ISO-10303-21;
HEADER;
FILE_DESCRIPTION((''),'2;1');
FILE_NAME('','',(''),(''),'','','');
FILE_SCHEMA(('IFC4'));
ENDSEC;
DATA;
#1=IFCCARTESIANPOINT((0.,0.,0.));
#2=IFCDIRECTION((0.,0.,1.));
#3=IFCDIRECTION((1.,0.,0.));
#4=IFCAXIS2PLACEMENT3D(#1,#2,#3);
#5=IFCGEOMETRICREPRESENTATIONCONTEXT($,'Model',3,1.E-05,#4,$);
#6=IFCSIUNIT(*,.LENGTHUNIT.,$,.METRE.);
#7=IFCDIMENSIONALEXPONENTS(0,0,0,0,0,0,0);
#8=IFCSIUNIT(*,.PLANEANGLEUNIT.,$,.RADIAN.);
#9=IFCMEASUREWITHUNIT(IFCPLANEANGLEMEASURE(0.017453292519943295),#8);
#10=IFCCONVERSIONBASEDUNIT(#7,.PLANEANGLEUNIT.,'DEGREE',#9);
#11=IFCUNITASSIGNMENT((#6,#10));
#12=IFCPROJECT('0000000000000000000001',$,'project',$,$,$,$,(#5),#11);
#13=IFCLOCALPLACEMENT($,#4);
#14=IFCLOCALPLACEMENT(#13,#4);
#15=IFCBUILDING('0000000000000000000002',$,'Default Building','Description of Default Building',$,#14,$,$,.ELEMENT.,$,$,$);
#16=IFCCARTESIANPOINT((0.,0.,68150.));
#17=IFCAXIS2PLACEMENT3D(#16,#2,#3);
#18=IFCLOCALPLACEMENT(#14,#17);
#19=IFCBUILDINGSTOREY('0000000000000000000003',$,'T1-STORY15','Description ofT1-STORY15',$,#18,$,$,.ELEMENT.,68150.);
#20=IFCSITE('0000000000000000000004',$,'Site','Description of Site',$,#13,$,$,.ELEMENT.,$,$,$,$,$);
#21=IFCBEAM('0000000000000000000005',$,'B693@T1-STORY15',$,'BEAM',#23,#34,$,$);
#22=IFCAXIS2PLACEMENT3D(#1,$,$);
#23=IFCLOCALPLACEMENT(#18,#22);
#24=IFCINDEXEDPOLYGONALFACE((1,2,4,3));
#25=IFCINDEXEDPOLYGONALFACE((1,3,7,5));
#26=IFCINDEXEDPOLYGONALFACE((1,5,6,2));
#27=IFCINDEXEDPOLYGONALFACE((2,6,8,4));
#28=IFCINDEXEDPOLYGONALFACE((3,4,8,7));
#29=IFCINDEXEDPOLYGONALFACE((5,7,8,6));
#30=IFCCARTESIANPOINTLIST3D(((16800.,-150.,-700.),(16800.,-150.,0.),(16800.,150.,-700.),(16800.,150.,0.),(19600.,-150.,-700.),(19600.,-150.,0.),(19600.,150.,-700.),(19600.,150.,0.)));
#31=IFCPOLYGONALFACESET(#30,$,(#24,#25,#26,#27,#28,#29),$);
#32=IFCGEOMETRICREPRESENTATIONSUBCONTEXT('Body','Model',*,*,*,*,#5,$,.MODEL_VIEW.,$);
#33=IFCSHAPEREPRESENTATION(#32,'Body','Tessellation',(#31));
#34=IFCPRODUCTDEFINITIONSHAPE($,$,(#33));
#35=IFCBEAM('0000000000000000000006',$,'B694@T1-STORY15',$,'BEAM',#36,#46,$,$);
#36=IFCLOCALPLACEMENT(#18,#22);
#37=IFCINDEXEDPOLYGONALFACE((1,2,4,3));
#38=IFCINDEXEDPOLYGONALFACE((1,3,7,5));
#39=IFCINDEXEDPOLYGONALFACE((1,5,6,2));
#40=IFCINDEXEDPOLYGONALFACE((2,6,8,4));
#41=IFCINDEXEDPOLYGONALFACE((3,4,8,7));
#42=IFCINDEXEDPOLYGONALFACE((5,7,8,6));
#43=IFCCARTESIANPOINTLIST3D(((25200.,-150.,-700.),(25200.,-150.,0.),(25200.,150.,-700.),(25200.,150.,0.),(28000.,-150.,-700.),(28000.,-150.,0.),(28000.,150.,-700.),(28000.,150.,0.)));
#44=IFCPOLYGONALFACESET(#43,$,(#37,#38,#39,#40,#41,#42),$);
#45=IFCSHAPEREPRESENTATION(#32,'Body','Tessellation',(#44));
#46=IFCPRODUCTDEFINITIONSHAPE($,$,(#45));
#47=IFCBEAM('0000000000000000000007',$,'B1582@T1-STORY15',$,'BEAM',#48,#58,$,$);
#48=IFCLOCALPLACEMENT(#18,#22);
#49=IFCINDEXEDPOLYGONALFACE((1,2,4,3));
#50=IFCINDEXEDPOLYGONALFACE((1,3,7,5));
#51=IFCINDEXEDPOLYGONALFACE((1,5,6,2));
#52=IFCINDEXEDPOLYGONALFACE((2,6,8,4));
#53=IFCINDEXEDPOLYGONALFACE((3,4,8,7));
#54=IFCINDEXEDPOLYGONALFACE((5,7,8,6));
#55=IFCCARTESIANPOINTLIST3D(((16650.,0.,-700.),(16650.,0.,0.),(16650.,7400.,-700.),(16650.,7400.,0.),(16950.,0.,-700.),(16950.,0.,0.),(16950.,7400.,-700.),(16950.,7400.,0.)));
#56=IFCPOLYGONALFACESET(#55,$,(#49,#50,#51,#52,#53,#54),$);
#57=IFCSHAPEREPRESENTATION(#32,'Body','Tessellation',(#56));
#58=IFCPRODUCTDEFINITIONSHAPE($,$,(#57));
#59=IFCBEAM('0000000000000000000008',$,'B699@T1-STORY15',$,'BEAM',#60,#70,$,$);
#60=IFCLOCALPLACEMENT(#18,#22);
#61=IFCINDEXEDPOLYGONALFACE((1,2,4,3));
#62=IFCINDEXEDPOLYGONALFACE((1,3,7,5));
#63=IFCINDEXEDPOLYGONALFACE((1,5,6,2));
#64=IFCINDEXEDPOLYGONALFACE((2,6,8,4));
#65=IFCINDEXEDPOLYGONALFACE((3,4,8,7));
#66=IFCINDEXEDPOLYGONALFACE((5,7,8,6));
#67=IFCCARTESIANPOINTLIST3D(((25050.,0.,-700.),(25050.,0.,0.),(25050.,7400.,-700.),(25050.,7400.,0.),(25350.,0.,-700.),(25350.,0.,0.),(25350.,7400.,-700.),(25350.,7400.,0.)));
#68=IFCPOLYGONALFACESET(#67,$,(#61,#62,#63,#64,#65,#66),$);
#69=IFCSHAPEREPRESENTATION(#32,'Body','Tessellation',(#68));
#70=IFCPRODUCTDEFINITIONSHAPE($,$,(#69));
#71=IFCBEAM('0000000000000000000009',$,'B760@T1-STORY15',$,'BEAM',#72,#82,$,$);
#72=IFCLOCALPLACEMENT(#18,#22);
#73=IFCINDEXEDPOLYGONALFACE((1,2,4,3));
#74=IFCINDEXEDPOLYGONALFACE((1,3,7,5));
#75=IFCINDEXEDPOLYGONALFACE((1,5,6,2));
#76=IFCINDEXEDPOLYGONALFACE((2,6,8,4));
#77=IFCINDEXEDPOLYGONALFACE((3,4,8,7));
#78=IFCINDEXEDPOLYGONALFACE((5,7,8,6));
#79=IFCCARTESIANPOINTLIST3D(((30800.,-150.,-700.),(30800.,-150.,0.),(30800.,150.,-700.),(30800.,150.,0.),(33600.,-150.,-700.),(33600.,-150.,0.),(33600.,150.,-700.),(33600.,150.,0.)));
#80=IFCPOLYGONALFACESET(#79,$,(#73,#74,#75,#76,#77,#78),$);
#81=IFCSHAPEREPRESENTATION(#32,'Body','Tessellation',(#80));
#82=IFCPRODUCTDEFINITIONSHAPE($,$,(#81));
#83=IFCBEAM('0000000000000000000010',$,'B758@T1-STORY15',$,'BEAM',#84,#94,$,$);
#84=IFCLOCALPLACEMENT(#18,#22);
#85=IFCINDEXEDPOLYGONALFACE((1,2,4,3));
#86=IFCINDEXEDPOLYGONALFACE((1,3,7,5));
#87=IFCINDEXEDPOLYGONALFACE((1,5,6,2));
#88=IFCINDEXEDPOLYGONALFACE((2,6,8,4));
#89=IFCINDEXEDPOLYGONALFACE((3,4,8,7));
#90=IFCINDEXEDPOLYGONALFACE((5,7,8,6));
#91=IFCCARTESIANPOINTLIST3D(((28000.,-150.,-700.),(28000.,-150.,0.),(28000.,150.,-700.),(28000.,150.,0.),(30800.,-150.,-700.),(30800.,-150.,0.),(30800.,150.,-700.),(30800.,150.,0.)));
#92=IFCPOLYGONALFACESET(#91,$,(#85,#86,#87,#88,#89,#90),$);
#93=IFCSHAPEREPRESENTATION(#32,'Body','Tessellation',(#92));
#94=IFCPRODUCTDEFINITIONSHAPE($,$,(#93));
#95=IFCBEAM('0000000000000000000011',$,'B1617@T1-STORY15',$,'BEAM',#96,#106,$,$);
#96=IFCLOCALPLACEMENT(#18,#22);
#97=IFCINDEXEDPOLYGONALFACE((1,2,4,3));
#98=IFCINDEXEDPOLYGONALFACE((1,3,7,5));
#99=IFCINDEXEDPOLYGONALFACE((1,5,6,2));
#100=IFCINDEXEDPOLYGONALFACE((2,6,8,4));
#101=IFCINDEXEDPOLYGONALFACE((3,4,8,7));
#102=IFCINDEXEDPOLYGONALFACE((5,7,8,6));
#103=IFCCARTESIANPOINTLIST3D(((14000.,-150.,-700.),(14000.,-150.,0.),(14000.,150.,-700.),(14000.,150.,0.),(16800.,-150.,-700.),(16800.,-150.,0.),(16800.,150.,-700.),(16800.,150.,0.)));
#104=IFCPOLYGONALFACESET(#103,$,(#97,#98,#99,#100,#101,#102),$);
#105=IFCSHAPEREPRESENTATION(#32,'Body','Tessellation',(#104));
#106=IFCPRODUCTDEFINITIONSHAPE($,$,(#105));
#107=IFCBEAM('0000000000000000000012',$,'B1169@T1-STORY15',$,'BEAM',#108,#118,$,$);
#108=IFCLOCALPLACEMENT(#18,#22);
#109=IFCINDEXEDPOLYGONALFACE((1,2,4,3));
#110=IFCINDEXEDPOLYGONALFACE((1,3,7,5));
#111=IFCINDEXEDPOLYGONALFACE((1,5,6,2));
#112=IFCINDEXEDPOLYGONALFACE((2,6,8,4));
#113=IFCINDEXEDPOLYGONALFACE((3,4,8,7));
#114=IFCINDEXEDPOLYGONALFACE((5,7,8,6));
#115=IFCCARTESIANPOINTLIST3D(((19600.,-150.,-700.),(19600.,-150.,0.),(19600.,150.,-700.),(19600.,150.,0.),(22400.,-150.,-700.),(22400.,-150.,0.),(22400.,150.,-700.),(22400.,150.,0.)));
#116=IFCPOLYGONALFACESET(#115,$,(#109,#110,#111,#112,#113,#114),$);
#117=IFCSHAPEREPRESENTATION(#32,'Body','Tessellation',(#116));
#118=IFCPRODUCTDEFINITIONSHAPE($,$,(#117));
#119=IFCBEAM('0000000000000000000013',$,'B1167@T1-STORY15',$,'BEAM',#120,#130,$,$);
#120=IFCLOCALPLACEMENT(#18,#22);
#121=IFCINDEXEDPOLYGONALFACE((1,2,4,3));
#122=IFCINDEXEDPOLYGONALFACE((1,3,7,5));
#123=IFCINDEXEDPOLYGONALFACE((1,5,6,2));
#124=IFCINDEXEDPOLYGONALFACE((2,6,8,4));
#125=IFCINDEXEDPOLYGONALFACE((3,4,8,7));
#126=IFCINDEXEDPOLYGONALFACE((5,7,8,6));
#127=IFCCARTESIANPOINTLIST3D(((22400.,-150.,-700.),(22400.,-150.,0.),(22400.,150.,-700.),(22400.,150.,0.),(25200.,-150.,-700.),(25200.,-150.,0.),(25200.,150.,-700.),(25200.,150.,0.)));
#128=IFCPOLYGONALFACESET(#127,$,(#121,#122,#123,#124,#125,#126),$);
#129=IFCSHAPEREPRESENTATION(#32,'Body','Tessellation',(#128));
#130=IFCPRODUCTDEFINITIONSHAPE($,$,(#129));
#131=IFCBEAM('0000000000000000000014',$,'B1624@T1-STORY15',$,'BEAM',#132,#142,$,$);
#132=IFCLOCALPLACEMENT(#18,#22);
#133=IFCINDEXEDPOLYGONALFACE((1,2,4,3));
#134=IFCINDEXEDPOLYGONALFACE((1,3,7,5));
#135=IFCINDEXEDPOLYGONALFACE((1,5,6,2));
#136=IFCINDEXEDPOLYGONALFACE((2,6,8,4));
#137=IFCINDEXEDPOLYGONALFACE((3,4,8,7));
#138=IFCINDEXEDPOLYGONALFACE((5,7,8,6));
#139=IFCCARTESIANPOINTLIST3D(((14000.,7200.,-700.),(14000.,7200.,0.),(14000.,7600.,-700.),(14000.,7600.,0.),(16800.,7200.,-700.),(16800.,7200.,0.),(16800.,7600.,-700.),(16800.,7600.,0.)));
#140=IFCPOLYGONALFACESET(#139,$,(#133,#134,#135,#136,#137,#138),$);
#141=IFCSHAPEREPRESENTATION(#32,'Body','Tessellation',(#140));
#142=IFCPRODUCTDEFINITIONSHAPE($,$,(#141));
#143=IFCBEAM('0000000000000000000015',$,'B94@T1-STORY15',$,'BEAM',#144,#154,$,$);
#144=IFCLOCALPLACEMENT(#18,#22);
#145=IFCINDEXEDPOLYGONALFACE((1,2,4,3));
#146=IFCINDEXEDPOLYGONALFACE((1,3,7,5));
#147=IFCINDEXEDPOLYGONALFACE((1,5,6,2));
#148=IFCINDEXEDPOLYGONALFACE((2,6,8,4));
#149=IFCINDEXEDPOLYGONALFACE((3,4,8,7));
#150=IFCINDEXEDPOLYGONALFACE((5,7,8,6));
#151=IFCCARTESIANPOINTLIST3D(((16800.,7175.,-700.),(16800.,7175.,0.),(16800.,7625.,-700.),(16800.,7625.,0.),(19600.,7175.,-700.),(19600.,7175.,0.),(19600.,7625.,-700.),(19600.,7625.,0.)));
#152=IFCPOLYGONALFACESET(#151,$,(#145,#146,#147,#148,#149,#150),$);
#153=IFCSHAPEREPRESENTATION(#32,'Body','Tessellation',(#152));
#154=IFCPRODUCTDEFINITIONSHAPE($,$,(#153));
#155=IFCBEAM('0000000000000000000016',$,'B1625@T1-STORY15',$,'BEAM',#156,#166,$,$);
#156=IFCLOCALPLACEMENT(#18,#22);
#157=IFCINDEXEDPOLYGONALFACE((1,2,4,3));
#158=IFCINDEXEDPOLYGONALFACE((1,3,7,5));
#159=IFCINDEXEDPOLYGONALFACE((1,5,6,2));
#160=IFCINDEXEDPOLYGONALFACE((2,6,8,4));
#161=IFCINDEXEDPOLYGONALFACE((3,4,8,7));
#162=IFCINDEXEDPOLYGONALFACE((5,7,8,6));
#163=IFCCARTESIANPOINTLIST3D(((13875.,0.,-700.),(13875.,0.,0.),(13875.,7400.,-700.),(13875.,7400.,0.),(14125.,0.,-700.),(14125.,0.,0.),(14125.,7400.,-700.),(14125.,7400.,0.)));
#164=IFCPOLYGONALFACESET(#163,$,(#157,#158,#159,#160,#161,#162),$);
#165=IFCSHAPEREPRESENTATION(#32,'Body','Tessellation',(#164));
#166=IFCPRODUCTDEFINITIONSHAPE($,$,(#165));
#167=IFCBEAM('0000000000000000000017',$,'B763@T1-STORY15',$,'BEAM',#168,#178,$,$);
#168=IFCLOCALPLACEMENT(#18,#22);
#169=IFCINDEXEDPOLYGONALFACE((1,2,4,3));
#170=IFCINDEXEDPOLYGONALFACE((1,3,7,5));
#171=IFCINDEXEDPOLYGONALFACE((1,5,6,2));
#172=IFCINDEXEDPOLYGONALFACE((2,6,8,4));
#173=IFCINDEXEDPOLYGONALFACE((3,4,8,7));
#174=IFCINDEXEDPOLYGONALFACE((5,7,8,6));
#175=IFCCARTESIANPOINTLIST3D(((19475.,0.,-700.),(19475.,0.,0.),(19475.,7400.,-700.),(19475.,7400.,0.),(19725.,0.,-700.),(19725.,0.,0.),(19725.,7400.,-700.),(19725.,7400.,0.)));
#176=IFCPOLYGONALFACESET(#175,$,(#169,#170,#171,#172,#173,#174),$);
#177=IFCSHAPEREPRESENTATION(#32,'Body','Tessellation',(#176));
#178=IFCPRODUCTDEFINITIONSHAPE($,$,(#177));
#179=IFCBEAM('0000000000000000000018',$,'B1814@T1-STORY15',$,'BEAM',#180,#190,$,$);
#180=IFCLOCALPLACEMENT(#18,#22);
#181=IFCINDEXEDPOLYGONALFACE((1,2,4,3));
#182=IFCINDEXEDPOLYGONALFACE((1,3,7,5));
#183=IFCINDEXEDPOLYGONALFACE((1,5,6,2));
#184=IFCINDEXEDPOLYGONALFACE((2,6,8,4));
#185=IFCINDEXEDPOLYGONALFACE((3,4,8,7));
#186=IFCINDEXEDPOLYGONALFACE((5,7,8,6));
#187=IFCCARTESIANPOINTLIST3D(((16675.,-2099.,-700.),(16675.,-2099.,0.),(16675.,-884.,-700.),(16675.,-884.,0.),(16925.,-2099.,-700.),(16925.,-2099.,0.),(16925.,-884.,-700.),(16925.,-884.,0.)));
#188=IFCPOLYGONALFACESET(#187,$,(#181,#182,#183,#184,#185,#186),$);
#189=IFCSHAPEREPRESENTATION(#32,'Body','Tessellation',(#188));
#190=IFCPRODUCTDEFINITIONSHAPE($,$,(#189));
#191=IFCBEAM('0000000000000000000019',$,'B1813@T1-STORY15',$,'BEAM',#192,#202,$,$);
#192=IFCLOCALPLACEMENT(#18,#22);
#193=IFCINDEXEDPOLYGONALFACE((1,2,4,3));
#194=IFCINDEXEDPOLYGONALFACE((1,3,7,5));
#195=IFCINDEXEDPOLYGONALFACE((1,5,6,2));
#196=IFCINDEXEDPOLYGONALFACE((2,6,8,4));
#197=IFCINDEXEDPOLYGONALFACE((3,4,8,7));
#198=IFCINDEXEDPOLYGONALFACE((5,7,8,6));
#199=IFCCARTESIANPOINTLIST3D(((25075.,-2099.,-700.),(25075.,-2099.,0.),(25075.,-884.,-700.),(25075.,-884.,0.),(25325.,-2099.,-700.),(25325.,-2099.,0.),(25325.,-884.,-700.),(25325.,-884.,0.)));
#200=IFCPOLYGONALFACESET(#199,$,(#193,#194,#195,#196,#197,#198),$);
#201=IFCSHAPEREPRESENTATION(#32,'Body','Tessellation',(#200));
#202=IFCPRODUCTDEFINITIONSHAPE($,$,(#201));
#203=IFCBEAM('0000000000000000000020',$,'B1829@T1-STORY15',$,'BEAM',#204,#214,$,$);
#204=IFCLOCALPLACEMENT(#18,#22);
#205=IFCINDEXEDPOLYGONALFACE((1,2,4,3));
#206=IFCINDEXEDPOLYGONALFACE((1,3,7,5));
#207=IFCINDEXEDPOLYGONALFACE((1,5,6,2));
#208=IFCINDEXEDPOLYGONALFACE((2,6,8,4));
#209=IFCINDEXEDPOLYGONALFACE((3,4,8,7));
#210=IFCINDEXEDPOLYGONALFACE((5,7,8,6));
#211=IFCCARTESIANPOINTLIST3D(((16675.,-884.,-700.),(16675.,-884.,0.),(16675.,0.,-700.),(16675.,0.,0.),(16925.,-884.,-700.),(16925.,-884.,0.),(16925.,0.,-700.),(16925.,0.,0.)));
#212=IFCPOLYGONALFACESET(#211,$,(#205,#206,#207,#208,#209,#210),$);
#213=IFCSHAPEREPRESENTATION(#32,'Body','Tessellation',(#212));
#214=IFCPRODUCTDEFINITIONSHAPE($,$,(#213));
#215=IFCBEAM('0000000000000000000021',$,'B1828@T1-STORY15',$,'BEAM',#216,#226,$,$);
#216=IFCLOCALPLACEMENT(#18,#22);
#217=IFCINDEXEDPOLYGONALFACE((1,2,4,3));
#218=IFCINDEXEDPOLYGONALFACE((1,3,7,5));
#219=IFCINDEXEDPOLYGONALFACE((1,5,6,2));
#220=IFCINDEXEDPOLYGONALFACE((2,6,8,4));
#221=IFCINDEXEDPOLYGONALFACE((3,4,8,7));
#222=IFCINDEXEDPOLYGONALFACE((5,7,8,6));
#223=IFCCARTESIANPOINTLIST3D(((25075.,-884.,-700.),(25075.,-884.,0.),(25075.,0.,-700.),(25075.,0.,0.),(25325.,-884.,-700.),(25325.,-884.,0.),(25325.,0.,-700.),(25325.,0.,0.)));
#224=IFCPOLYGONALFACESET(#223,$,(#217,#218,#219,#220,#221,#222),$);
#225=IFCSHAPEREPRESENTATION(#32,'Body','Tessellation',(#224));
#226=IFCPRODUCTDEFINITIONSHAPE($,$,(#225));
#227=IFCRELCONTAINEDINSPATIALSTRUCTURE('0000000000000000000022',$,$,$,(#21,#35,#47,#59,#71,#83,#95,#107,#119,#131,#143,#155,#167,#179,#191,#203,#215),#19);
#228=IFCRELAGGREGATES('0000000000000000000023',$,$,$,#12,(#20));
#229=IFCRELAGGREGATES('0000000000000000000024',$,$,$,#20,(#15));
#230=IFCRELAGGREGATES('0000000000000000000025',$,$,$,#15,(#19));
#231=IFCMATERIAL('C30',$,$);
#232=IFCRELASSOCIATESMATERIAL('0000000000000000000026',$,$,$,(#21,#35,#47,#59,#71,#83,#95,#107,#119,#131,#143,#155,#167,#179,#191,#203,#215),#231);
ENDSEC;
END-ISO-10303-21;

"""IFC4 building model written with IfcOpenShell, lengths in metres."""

from ifc_helpers import new_model, entity, si_unit, converted_unit, frame, origin_with_axes, place, context, subcontext, project, spatial, rectangle, extrude, material, element, save


model = new_model("IFC4")

# Units and contexts
model_context = context("Model", 3, precision=1e-05, world=origin_with_axes())
body_context = subcontext(model_context, "Body", "Model", "MODEL_VIEW")
ifc_project = project(units=[si_unit("LENGTHUNIT", "METRE"), converted_unit("PLANEANGLEUNIT", "DEGREE", entity("IfcPlaneAngleMeasure", 0.017453292519943295), si_unit("PLANEANGLEUNIT", "RADIAN"), dimensions=[0, 0, 0, 0, 0, 0, 0])], contexts=[model_context])

# Site, building, storey
site_placement = place(None, origin_with_axes())
site = spatial("IfcSite", under=ifc_project, at=site_placement, Name="Site", Description="Description of Site", CompositionType="ELEMENT")
building_placement = place(site_placement, origin_with_axes())
building = spatial("IfcBuilding", under=site, at=building_placement, Name="Default Building", Description="Description of Default Building", CompositionType="ELEMENT")
storey_placement = place(building_placement, frame((0.0, 0.0, 68150.0), z_axis=(0.0, 0.0, 1.0), x_axis=(1.0, 0.0, 0.0)))
storey = spatial("IfcBuildingStorey", under=building, at=storey_placement, Name="T1-STORY15", Description="Description ofT1-STORY15", CompositionType="ELEMENT", Elevation=68150.0)

# Beams
ifc_material_1 = material(Name="C30")
for number, where, z_axis, x_axis, name in (
    (1, (16800.0, 0.0, -350.0), (1.0, 0.0, 0.0), (0.0, 1.0, 0.0), "B693@T1-STORY15"),
    (2, (25200.0, 0.0, -350.0), (1.0, 0.0, 0.0), (0.0, 1.0, 0.0), "B694@T1-STORY15"),
):
    element("IfcBeam", number, at=place(storey_placement, frame(where, z_axis=z_axis, x_axis=x_axis)), inside=storey, material=ifc_material_1, Name=name, ObjectType="BEAM", context=body_context, shape_type="SweptSolid", body=[
        extrude(rectangle(XDim=300.0, YDim=700.0), origin_with_axes(), (0.0, 0.0, 1.0), 2800.0),
    ])
for number, where, z_axis, x_axis, name in (
    (3, (16800.0, 0.0, -350.0), (0.0, 1.0, 0.0), (-1.0, 0.0, 0.0), "B1582@T1-STORY15"),
    (4, (25200.0, 0.0, -350.0), (0.0, 1.0, 0.0), (-1.0, 0.0, 0.0), "B699@T1-STORY15"),
):
    element("IfcBeam", number, at=place(storey_placement, frame(where, z_axis=z_axis, x_axis=x_axis)), inside=storey, material=ifc_material_1, Name=name, ObjectType="BEAM", context=body_context, shape_type="SweptSolid", body=[
        extrude(rectangle(XDim=300.0, YDim=700.0), origin_with_axes(), (0.0, 0.0, 1.0), 7400.0),
    ])
for number, where, z_axis, x_axis, name in (
    (5, (30800.0, 0.0, -350.0), (1.0, 0.0, 0.0), (0.0, 1.0, 0.0), "B760@T1-STORY15"),
    (6, (28000.0, 0.0, -350.0), (1.0, 0.0, 0.0), (0.0, 1.0, 0.0), "B758@T1-STORY15"),
    (7, (14000.0, 0.0, -350.0), (1.0, 0.0, 0.0), (0.0, 1.0, 0.0), "B1617@T1-STORY15"),
    (8, (19600.0, 0.0, -350.0), (1.0, 0.0, 0.0), (0.0, 1.0, 0.0), "B1169@T1-STORY15"),
    (9, (22400.0, 0.0, -350.0), (1.0, 0.0, 0.0), (0.0, 1.0, 0.0), "B1167@T1-STORY15"),
):
    element("IfcBeam", number, at=place(storey_placement, frame(where, z_axis=z_axis, x_axis=x_axis)), inside=storey, material=ifc_material_1, Name=name, ObjectType="BEAM", context=body_context, shape_type="SweptSolid", body=[
        extrude(rectangle(XDim=300.0, YDim=700.0), origin_with_axes(), (0.0, 0.0, 1.0), 2800.0),
    ])
beam_1_placement = place(storey_placement, frame((14000.0, 7400.0, -350.0), z_axis=(1.0, 0.0, 0.0), x_axis=(0.0, 1.0, 0.0)))
element("IfcBeam", 10, at=beam_1_placement, inside=storey, material=ifc_material_1, Name="B1624@T1-STORY15", ObjectType="BEAM", context=body_context, shape_type="SweptSolid", body=[
    extrude(rectangle(XDim=400.0, YDim=700.0), origin_with_axes(), (0.0, 0.0, 1.0), 2800.0),
])
beam_2_placement = place(storey_placement, frame((16800.0, 7400.0, -350.0), z_axis=(1.0, 0.0, 0.0), x_axis=(0.0, 1.0, 0.0)))
element("IfcBeam", 11, at=beam_2_placement, inside=storey, material=ifc_material_1, Name="B94@T1-STORY15", ObjectType="BEAM", context=body_context, shape_type="SweptSolid", body=[
    extrude(rectangle(XDim=450.0, YDim=700.0), origin_with_axes(), (0.0, 0.0, 1.0), 2800.0),
])
for number, where, z_axis, x_axis, name in (
    (12, (14000.0, 0.0, -350.0), (0.0, 1.0, 0.0), (-1.0, 0.0, 0.0), "B1625@T1-STORY15"),
    (13, (19600.0, 0.0, -350.0), (0.0, 1.0, 0.0), (-1.0, 0.0, 0.0), "B763@T1-STORY15"),
):
    element("IfcBeam", number, at=place(storey_placement, frame(where, z_axis=z_axis, x_axis=x_axis)), inside=storey, material=ifc_material_1, Name=name, ObjectType="BEAM", context=body_context, shape_type="SweptSolid", body=[
        extrude(rectangle(XDim=250.0, YDim=700.0), origin_with_axes(), (0.0, 0.0, 1.0), 7400.0),
    ])
for number, where, z_axis, x_axis, name in (
    (14, (16800.0, -2099.0, -350.0), (0.0, 1.0, 0.0), (-1.0, 0.0, 0.0), "B1814@T1-STORY15"),
    (15, (25200.0, -2099.0, -350.0), (0.0, 1.0, 0.0), (-1.0, 0.0, 0.0), "B1813@T1-STORY15"),
):
    element("IfcBeam", number, at=place(storey_placement, frame(where, z_axis=z_axis, x_axis=x_axis)), inside=storey, material=ifc_material_1, Name=name, ObjectType="BEAM", context=body_context, shape_type="SweptSolid", body=[
        extrude(rectangle(XDim=250.0, YDim=700.0), origin_with_axes(), (0.0, 0.0, 1.0), 1215.0),
    ])
for number, where, z_axis, x_axis, name in (
    (16, (16800.0, -884.0, -350.0), (0.0, 1.0, 0.0), (-1.0, 0.0, 0.0), "B1829@T1-STORY15"),
    (17, (25200.0, -884.0, -350.0), (0.0, 1.0, 0.0), (-1.0, 0.0, 0.0), "B1828@T1-STORY15"),
):
    element("IfcBeam", number, at=place(storey_placement, frame(where, z_axis=z_axis, x_axis=x_axis)), inside=storey, material=ifc_material_1, Name=name, ObjectType="BEAM", context=body_context, shape_type="SweptSolid", body=[
        extrude(rectangle(XDim=250.0, YDim=700.0), origin_with_axes(), (0.0, 0.0, 1.0), 884.0),
    ])

save(model, "model.ifc")
